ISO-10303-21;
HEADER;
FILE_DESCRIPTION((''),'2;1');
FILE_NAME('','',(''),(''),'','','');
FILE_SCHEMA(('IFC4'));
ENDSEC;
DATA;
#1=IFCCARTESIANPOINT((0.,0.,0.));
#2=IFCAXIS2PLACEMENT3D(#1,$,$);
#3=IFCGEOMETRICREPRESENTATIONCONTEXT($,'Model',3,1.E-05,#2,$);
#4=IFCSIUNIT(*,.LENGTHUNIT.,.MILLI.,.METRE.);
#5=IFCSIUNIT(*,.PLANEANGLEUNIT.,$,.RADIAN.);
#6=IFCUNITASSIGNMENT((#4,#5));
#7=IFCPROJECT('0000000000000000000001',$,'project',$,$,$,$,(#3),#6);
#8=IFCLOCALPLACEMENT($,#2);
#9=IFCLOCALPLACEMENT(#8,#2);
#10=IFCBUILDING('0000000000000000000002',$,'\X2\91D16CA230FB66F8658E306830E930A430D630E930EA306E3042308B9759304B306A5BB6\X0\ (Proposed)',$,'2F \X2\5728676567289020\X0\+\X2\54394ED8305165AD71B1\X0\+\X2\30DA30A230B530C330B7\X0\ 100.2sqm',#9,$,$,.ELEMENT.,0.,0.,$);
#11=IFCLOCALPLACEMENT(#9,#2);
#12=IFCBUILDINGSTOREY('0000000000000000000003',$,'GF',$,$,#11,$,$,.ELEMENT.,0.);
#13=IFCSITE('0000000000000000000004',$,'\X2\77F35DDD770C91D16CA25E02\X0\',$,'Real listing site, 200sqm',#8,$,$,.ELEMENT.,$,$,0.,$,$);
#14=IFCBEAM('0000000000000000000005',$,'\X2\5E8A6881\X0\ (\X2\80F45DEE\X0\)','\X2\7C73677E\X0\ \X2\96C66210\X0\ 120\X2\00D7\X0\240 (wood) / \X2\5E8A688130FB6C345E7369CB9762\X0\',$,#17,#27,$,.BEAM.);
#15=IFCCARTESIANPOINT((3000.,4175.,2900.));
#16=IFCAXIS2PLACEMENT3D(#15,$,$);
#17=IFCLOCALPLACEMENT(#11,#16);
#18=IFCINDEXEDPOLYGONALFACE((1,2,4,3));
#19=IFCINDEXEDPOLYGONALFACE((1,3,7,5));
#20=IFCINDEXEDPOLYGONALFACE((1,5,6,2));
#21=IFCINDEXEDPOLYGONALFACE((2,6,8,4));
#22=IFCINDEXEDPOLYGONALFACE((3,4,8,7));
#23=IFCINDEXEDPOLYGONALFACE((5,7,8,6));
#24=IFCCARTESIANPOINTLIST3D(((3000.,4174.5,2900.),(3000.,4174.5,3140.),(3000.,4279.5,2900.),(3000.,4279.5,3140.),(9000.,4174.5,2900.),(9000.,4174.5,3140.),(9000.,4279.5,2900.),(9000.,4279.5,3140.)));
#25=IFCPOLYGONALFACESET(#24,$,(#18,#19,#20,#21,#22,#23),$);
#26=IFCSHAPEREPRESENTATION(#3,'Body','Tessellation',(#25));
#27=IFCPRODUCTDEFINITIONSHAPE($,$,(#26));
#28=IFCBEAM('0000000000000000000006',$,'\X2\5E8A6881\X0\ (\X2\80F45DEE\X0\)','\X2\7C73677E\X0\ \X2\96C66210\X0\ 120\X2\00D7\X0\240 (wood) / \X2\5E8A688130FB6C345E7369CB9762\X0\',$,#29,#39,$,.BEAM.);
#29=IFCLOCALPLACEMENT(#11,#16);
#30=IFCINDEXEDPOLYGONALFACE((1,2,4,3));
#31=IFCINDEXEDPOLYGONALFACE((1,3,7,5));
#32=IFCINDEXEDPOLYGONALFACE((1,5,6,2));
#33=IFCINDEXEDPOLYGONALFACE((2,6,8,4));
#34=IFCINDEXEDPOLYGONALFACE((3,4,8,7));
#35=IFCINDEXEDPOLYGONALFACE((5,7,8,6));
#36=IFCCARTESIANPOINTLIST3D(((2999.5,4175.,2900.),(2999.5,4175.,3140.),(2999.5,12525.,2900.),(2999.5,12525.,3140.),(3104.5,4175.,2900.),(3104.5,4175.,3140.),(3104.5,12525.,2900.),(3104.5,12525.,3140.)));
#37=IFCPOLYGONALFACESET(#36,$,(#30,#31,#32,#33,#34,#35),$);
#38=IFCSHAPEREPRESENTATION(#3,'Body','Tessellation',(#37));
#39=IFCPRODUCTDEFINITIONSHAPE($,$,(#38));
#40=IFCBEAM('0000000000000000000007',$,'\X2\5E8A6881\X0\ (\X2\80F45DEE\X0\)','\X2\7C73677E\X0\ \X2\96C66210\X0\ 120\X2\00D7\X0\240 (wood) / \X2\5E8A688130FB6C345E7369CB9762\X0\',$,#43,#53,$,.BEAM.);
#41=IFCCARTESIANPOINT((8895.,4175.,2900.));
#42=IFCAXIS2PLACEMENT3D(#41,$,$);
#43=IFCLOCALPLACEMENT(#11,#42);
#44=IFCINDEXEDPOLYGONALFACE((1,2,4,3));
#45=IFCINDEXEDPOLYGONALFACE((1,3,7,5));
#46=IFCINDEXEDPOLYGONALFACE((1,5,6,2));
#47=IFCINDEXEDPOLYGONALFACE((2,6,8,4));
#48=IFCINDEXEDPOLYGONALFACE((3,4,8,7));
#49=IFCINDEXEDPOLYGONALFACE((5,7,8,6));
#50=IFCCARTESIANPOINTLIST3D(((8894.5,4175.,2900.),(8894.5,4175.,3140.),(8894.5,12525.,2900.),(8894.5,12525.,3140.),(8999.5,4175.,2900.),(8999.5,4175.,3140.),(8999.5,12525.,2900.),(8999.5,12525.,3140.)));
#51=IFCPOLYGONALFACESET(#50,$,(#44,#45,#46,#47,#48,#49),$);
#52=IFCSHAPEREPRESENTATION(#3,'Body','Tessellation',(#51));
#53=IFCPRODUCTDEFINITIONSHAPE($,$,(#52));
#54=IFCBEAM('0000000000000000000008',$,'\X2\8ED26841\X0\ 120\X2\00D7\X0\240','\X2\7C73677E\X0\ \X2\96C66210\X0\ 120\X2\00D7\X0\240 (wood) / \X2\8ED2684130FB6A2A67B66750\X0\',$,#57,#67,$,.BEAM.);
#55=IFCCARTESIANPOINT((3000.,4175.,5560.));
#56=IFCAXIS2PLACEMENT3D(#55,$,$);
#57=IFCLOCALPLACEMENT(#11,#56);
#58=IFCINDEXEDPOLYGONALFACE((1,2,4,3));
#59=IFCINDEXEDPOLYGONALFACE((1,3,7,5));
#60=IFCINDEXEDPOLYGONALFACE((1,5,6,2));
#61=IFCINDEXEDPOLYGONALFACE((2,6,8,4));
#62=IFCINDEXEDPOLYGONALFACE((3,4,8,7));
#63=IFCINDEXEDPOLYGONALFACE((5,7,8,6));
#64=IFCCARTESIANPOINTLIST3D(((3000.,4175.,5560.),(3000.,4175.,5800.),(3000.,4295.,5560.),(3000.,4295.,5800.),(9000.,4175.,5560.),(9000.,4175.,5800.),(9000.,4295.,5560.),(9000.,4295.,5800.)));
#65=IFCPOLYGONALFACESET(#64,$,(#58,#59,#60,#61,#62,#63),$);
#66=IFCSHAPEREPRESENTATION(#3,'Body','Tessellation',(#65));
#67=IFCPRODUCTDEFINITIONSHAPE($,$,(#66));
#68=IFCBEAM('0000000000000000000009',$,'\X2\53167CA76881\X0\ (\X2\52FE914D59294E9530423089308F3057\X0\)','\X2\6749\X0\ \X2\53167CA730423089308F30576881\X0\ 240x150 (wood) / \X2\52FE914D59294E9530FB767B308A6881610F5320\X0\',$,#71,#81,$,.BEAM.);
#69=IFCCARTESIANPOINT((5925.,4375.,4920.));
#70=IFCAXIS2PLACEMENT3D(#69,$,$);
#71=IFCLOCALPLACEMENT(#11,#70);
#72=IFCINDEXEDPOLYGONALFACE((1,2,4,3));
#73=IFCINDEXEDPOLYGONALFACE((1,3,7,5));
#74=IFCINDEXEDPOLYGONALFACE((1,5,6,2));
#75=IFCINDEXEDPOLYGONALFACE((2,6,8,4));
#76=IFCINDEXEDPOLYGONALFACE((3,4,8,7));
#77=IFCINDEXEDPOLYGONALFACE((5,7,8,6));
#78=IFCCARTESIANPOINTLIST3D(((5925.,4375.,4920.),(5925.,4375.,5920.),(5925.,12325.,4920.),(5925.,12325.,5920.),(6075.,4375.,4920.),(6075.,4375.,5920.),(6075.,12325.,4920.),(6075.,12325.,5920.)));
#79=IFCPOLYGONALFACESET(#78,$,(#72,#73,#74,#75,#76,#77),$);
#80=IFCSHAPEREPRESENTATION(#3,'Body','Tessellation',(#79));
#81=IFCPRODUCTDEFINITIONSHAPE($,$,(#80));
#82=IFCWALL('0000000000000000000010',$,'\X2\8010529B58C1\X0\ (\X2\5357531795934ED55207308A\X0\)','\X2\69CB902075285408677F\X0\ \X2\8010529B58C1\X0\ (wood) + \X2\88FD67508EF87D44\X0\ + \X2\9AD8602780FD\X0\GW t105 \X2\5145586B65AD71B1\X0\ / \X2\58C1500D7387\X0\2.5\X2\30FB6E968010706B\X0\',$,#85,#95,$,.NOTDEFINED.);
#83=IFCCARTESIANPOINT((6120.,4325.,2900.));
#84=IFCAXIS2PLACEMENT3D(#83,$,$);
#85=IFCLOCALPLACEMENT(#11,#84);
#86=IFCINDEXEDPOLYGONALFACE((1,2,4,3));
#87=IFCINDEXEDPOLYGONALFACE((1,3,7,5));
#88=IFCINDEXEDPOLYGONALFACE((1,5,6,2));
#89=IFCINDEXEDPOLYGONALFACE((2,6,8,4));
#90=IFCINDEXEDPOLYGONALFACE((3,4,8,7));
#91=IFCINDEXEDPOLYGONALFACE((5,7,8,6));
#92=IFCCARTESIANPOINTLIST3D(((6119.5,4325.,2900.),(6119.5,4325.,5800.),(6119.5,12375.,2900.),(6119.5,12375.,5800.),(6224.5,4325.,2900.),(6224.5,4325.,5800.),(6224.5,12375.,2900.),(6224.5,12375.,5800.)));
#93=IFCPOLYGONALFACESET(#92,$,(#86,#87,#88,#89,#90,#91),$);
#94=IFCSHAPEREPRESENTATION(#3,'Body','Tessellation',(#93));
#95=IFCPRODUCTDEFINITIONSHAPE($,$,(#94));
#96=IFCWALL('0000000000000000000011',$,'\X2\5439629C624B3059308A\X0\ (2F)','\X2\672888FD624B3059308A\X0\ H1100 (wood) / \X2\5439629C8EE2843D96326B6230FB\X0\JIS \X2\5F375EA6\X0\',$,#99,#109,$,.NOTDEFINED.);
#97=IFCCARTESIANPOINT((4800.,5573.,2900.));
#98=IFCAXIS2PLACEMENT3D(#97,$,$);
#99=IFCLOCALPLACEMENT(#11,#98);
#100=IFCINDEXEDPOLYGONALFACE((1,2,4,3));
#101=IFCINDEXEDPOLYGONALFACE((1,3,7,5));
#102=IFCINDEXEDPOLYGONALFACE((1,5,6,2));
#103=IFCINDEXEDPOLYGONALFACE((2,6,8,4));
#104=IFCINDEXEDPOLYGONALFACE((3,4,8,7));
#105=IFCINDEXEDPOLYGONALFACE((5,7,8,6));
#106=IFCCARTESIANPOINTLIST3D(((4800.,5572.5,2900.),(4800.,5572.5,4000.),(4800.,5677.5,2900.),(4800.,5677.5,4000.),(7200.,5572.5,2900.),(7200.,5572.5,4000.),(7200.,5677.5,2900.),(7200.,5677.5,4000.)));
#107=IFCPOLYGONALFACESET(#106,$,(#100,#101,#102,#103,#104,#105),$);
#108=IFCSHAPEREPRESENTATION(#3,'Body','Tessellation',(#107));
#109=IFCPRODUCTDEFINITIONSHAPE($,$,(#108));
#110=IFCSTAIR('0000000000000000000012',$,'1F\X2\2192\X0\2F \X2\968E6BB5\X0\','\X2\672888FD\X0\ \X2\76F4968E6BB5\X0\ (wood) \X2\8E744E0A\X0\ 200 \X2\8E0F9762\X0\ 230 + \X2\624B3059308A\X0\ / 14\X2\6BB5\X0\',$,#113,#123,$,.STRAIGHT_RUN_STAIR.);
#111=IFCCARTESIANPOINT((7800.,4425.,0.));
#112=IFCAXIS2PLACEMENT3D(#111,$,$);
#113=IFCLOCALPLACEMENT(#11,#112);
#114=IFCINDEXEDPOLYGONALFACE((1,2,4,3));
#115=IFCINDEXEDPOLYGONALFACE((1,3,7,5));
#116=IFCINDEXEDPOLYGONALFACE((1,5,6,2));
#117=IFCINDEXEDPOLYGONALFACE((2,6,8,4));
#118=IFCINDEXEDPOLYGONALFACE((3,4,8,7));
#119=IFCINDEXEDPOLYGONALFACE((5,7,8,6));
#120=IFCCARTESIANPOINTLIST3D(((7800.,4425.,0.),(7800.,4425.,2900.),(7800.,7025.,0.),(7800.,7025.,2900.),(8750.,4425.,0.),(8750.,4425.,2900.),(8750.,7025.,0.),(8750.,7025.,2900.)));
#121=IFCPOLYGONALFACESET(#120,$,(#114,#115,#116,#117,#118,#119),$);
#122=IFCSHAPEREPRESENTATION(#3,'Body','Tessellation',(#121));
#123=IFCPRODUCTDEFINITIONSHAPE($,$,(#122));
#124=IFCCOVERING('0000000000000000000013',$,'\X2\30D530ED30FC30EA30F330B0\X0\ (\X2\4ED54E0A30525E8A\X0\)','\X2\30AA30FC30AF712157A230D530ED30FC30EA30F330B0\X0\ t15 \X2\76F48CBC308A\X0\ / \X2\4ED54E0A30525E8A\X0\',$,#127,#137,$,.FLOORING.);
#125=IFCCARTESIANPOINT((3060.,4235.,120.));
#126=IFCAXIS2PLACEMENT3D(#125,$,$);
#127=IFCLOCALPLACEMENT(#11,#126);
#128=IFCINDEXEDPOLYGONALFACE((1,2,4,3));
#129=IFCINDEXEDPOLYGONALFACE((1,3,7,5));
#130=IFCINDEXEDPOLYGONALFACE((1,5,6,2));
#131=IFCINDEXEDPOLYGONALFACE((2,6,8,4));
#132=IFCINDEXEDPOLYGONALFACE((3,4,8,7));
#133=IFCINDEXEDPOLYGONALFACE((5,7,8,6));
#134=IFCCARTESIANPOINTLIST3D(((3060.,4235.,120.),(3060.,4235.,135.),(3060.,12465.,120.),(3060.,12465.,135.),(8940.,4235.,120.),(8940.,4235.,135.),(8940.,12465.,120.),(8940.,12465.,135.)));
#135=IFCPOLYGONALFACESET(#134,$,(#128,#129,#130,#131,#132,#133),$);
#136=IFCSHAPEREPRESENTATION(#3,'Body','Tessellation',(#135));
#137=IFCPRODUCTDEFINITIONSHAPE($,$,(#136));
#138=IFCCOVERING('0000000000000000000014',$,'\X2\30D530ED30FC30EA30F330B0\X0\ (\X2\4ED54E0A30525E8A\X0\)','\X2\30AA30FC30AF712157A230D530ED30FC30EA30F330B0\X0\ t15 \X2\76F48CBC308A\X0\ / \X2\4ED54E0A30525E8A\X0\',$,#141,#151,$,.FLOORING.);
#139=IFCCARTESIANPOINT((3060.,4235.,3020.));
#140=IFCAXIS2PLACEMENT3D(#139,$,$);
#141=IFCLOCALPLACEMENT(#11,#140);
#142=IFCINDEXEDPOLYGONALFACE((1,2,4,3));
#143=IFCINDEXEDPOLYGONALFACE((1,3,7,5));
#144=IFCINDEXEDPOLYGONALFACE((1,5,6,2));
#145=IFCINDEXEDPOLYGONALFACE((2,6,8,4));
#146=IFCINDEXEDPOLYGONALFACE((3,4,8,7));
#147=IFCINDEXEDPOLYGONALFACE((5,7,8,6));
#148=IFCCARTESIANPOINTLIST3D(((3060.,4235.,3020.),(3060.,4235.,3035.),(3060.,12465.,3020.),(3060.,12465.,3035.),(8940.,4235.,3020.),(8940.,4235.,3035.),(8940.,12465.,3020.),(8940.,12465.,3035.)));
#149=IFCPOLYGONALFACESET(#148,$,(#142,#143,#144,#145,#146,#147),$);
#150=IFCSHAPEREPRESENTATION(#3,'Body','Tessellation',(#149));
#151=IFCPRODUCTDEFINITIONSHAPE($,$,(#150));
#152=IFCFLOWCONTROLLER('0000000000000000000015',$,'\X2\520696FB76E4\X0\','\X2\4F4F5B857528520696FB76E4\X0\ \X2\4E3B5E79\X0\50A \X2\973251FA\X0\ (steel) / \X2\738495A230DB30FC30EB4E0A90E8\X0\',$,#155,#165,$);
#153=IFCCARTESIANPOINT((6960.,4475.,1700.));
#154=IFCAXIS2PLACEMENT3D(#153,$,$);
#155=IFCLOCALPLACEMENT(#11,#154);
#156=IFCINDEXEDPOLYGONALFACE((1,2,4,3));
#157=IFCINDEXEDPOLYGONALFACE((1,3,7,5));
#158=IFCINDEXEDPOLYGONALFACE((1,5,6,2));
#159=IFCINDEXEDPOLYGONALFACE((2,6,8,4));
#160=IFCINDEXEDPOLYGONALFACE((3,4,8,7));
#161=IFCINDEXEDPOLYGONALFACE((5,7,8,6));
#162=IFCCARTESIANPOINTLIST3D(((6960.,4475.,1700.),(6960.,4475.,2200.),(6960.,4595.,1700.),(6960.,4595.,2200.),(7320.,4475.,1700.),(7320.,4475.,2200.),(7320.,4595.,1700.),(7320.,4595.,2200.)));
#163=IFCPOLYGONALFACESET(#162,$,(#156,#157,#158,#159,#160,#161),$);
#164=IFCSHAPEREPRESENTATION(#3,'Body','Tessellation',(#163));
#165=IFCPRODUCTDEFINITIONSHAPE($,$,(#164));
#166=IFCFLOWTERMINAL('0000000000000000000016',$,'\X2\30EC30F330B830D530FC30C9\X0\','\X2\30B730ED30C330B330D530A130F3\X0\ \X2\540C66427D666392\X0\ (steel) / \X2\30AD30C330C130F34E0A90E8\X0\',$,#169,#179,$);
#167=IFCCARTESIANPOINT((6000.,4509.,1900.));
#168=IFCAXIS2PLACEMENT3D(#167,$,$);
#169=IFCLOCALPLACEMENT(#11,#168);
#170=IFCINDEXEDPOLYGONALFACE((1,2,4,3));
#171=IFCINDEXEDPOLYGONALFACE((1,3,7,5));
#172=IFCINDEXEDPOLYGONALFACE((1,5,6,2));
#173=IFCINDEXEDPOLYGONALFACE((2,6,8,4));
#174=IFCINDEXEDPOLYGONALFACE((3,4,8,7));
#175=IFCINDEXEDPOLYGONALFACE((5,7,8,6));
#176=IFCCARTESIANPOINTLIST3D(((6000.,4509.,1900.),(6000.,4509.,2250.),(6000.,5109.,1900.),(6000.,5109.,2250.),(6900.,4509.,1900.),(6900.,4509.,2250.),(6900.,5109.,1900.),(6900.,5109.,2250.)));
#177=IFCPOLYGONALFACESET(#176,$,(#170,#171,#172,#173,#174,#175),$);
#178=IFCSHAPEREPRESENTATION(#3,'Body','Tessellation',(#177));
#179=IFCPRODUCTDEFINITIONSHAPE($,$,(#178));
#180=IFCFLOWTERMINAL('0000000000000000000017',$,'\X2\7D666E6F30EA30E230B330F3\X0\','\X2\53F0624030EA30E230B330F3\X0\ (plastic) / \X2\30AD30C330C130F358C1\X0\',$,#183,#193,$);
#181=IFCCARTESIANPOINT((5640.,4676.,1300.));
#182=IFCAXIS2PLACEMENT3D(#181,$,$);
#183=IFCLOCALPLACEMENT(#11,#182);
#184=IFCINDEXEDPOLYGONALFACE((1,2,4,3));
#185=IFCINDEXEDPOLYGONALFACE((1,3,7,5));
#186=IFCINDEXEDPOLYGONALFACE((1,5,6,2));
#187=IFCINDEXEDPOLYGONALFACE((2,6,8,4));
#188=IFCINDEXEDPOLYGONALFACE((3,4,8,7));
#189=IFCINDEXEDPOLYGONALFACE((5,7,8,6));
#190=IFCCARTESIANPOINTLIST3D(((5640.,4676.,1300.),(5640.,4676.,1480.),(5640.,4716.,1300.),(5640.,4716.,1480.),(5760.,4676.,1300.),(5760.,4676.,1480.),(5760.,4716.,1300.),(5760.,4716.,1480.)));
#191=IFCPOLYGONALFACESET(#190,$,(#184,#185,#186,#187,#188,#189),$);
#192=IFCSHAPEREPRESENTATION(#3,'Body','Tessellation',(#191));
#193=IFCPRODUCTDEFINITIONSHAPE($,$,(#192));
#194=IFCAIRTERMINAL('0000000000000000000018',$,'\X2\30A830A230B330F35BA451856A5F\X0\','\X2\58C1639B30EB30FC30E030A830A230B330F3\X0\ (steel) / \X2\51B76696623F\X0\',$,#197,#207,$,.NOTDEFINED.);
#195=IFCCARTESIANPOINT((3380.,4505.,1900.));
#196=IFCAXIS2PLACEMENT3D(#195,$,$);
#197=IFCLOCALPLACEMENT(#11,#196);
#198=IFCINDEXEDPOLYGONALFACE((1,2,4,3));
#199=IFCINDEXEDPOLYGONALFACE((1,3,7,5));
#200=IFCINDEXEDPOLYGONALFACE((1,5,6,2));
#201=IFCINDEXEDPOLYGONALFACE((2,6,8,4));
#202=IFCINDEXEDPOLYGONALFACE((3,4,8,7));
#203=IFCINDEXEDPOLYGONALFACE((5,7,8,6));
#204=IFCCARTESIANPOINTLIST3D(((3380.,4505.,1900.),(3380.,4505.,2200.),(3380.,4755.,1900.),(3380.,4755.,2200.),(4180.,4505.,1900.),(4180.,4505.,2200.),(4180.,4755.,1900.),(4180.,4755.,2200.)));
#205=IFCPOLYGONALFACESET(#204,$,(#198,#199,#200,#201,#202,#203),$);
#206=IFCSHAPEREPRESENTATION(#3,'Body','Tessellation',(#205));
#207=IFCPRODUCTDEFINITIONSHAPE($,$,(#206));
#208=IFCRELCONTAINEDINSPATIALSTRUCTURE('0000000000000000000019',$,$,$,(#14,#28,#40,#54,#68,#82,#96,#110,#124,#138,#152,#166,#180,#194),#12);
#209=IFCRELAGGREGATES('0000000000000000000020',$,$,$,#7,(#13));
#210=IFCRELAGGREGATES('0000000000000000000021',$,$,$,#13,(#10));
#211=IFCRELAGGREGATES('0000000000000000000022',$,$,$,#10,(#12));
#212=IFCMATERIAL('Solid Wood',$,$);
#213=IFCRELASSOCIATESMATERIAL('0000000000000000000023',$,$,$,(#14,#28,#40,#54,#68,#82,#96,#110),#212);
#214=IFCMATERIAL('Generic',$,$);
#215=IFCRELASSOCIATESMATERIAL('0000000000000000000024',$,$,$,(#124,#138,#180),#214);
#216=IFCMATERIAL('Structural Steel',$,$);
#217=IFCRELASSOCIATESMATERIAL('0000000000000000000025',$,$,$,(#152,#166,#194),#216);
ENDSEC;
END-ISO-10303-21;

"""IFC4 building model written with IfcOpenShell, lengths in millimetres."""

from ifc_helpers import new_model, si_unit, frame, frame_2d, origin, place, context, project, spatial, rectangle, extrude, material, element, save


model = new_model("IFC4")

# Units and contexts
model_context = context("Model", 3, precision=1e-05, world=origin())
ifc_project = project(units=[si_unit("LENGTHUNIT", "METRE", prefix="MILLI"), si_unit("PLANEANGLEUNIT", "RADIAN")], contexts=[model_context])

# Site, building, storey
site_placement = place(None, origin())
site = spatial("IfcSite", under=ifc_project, at=site_placement, Name="石川県金沢市", ObjectType="Real listing site, 200sqm", CompositionType="ELEMENT", RefElevation=0.0)
building_placement = place(site_placement, origin())
building = spatial("IfcBuilding", under=site, at=building_placement, Name="金沢・書斎とライブラリのある静かな家 (Proposed)", ObjectType="2F 在来木造+吹付け断熱+ペアサッシ 100.2sqm", CompositionType="ELEMENT", ElevationOfRefHeight=0.0, ElevationOfTerrain=0.0)
storey_placement = place(building_placement, origin())
storey = spatial("IfcBuildingStorey", under=building, at=storey_placement, Name="GF", CompositionType="ELEMENT", Elevation=0.0)

# Shared definitions
ifc_material_1 = material(Name="Solid Wood")

# Beams
beam_1_placement = place(storey_placement, frame((3000.0, 4175.0, 2900.0)))
element("IfcBeam", 1, at=beam_1_placement, inside=storey, material=ifc_material_1, Name="床梁 (胴差)", Description="米松 集成 120×240 (wood) / 床梁・水平構面", PredefinedType="BEAM", context=model_context, shape_type="SweptSolid", body=[
    extrude(rectangle(XDim=6000.0, YDim=105.0, at=frame_2d((3000.0, 52.0))), frame((3000.0, 4175.0, 2900.0)), (0.0, 0.0, 1.0), 240.0),
])
beam_2_placement = place(storey_placement, frame((3000.0, 4175.0, 2900.0)))
element("IfcBeam", 2, at=beam_2_placement, inside=storey, material=ifc_material_1, Name="床梁 (胴差)", Description="米松 集成 120×240 (wood) / 床梁・水平構面", PredefinedType="BEAM", context=model_context, shape_type="SweptSolid", body=[
    extrude(rectangle(XDim=105.0, YDim=8350.0, at=frame_2d((52.0, 4175.0))), frame((3000.0, 4175.0, 2900.0)), (0.0, 0.0, 1.0), 240.0),
])
beam_3_placement = place(storey_placement, frame((8895.0, 4175.0, 2900.0)))
element("IfcBeam", 3, at=beam_3_placement, inside=storey, material=ifc_material_1, Name="床梁 (胴差)", Description="米松 集成 120×240 (wood) / 床梁・水平構面", PredefinedType="BEAM", context=model_context, shape_type="SweptSolid", body=[
    extrude(rectangle(XDim=105.0, YDim=8350.0, at=frame_2d((52.0, 4175.0))), frame((8895.0, 4175.0, 2900.0)), (0.0, 0.0, 1.0), 240.0),
])
beam_4_placement = place(storey_placement, frame((3000.0, 4175.0, 5560.0)))
element("IfcBeam", 4, at=beam_4_placement, inside=storey, material=ifc_material_1, Name="軒桁 120×240", Description="米松 集成 120×240 (wood) / 軒桁・横架材", PredefinedType="BEAM", context=model_context, shape_type="SweptSolid", body=[
    extrude(rectangle(XDim=6000.0, YDim=120.0, at=frame_2d((3000.0, 60.0))), frame((3000.0, 4175.0, 5560.0)), (0.0, 0.0, 1.0), 240.0),
])
beam_5_placement = place(storey_placement, frame((5925.0, 4375.0, 4920.0)))
element("IfcBeam", 5, at=beam_5_placement, inside=storey, material=ifc_material_1, Name="化粧梁 (勾配天井あらわし)", Description="杉 化粧あらわし梁 240x150 (wood) / 勾配天井・登り梁意匠", PredefinedType="BEAM", context=model_context, shape_type="SweptSolid", body=[
    extrude(rectangle(XDim=150.0, YDim=7950.0, at=frame_2d((75.0, 3975.0))), frame((5925.0, 4375.0, 4920.0)), (0.0, 0.0, 1.0), 1000.0),
])

# Walls
wall_1_placement = place(storey_placement, frame((6120.0, 4325.0, 2900.0)))
element("IfcWall", 6, at=wall_1_placement, inside=storey, material=ifc_material_1, Name="耐力壁 (南北間仕切り)", Description="構造用合板 耐力壁 (wood) + 製材軸組 + 高性能GW t105 充填断熱 / 壁倍率2.5・準耐火", PredefinedType="NOTDEFINED", context=model_context, shape_type="SweptSolid", body=[
    extrude(rectangle(XDim=105.0, YDim=8050.0, at=frame_2d((52.0, 4025.0))), frame((6120.0, 4325.0, 2900.0)), (0.0, 0.0, 1.0), 2900.0),
])
wall_2_placement = place(storey_placement, frame((4800.0, 5573.0, 2900.0)))
element("IfcWall", 7, at=wall_2_placement, inside=storey, material=ifc_material_1, Name="吹抜手すり (2F)", Description="木製手すり H1100 (wood) / 吹抜転落防止・JIS 強度", PredefinedType="NOTDEFINED", context=model_context, shape_type="SweptSolid", body=[
    extrude(rectangle(XDim=2400.0, YDim=105.0, at=frame_2d((1200.0, 52.0))), frame((4800.0, 5573.0, 2900.0)), (0.0, 0.0, 1.0), 1100.0),
])

# Stair
stair_placement = place(storey_placement, frame((7800.0, 4425.0, 0.0)))
element("IfcStair", 8, at=stair_placement, inside=storey, material=ifc_material_1, Name="1F→2F 階段", Description="木製 直階段 (wood) 蹴上 200 踏面 230 + 手すり / 14段", PredefinedType="STRAIGHT_RUN_STAIR", context=model_context, shape_type="SweptSolid", body=[
    extrude(rectangle(XDim=950.0, YDim=2600.0, at=frame_2d((475.0, 1300.0))), frame((7800.0, 4425.0, 0.0)), (0.0, 0.0, 1.0), 2900.0),
])

# Coverings
ifc_material_2 = material(Name="Generic")
covering_1_placement = place(storey_placement, frame((3060.0, 4235.0, 120.0)))
element("IfcCovering", 9, at=covering_1_placement, inside=storey, material=ifc_material_2, Name="フローリング (仕上げ床)", Description="オーク無垢フローリング t15 直貼り / 仕上げ床", PredefinedType="FLOORING", context=model_context, shape_type="SweptSolid", body=[
    extrude(rectangle(XDim=5880.0, YDim=8230.0, at=frame_2d((2940.0, 4115.0))), frame((3060.0, 4235.0, 120.0)), (0.0, 0.0, 1.0), 15.0),
])
covering_2_placement = place(storey_placement, frame((3060.0, 4235.0, 3020.0)))
element("IfcCovering", 10, at=covering_2_placement, inside=storey, material=ifc_material_2, Name="フローリング (仕上げ床)", Description="オーク無垢フローリング t15 直貼り / 仕上げ床", PredefinedType="FLOORING", context=model_context, shape_type="SweptSolid", body=[
    extrude(rectangle(XDim=5880.0, YDim=8230.0, at=frame_2d((2940.0, 4115.0))), frame((3060.0, 4235.0, 3020.0)), (0.0, 0.0, 1.0), 15.0),
])

# Flow controller
ifc_material_3 = material(Name="Structural Steel")
flow_controller_placement = place(storey_placement, frame((6960.0, 4475.0, 1700.0)))
element("IfcFlowController", 11, at=flow_controller_placement, inside=storey, material=ifc_material_3, Name="分電盤", Description="住宅用分電盤 主幹50A 露出 (steel) / 玄関ホール上部", context=model_context, shape_type="SweptSolid", body=[
    extrude(rectangle(XDim=360.0, YDim=120.0, at=frame_2d((180.0, 60.0))), frame((6960.0, 4475.0, 1700.0)), (0.0, 0.0, 1.0), 500.0),
])

# Flow terminals
flow_terminal_1_placement = place(storey_placement, frame((6000.0, 4509.0, 1900.0)))
element("IfcFlowTerminal", 12, at=flow_terminal_1_placement, inside=storey, material=ifc_material_3, Name="レンジフード", Description="シロッコファン 同時給排 (steel) / キッチン上部", context=model_context, shape_type="SweptSolid", body=[
    extrude(rectangle(XDim=900.0, YDim=600.0, at=frame_2d((450.0, 300.0))), frame((6000.0, 4509.0, 1900.0)), (0.0, 0.0, 1.0), 350.0),
])
flow_terminal_2_placement = place(storey_placement, frame((5640.0, 4676.0, 1300.0)))
element("IfcFlowTerminal", 13, at=flow_terminal_2_placement, inside=storey, material=ifc_material_2, Name="給湯リモコン", Description="台所リモコン (plastic) / キッチン壁", context=model_context, shape_type="SweptSolid", body=[
    extrude(rectangle(XDim=120.0, YDim=40.0, at=frame_2d((60.0, 20.0))), frame((5640.0, 4676.0, 1300.0)), (0.0, 0.0, 1.0), 180.0),
])

# Air terminal
air_terminal_1_placement = place(storey_placement, frame((3380.0, 4505.0, 1900.0)))
element("IfcAirTerminal", 14, at=air_terminal_1_placement, inside=storey, material=ifc_material_3, Name="エアコン室内機", Description="壁掛ルームエアコン (steel) / 冷暖房", PredefinedType="NOTDEFINED", context=model_context, shape_type="SweptSolid", body=[
    extrude(rectangle(XDim=800.0, YDim=250.0, at=frame_2d((400.0, 125.0))), frame((3380.0, 4505.0, 1900.0)), (0.0, 0.0, 1.0), 300.0),
])

save(model, "model.ifc")
